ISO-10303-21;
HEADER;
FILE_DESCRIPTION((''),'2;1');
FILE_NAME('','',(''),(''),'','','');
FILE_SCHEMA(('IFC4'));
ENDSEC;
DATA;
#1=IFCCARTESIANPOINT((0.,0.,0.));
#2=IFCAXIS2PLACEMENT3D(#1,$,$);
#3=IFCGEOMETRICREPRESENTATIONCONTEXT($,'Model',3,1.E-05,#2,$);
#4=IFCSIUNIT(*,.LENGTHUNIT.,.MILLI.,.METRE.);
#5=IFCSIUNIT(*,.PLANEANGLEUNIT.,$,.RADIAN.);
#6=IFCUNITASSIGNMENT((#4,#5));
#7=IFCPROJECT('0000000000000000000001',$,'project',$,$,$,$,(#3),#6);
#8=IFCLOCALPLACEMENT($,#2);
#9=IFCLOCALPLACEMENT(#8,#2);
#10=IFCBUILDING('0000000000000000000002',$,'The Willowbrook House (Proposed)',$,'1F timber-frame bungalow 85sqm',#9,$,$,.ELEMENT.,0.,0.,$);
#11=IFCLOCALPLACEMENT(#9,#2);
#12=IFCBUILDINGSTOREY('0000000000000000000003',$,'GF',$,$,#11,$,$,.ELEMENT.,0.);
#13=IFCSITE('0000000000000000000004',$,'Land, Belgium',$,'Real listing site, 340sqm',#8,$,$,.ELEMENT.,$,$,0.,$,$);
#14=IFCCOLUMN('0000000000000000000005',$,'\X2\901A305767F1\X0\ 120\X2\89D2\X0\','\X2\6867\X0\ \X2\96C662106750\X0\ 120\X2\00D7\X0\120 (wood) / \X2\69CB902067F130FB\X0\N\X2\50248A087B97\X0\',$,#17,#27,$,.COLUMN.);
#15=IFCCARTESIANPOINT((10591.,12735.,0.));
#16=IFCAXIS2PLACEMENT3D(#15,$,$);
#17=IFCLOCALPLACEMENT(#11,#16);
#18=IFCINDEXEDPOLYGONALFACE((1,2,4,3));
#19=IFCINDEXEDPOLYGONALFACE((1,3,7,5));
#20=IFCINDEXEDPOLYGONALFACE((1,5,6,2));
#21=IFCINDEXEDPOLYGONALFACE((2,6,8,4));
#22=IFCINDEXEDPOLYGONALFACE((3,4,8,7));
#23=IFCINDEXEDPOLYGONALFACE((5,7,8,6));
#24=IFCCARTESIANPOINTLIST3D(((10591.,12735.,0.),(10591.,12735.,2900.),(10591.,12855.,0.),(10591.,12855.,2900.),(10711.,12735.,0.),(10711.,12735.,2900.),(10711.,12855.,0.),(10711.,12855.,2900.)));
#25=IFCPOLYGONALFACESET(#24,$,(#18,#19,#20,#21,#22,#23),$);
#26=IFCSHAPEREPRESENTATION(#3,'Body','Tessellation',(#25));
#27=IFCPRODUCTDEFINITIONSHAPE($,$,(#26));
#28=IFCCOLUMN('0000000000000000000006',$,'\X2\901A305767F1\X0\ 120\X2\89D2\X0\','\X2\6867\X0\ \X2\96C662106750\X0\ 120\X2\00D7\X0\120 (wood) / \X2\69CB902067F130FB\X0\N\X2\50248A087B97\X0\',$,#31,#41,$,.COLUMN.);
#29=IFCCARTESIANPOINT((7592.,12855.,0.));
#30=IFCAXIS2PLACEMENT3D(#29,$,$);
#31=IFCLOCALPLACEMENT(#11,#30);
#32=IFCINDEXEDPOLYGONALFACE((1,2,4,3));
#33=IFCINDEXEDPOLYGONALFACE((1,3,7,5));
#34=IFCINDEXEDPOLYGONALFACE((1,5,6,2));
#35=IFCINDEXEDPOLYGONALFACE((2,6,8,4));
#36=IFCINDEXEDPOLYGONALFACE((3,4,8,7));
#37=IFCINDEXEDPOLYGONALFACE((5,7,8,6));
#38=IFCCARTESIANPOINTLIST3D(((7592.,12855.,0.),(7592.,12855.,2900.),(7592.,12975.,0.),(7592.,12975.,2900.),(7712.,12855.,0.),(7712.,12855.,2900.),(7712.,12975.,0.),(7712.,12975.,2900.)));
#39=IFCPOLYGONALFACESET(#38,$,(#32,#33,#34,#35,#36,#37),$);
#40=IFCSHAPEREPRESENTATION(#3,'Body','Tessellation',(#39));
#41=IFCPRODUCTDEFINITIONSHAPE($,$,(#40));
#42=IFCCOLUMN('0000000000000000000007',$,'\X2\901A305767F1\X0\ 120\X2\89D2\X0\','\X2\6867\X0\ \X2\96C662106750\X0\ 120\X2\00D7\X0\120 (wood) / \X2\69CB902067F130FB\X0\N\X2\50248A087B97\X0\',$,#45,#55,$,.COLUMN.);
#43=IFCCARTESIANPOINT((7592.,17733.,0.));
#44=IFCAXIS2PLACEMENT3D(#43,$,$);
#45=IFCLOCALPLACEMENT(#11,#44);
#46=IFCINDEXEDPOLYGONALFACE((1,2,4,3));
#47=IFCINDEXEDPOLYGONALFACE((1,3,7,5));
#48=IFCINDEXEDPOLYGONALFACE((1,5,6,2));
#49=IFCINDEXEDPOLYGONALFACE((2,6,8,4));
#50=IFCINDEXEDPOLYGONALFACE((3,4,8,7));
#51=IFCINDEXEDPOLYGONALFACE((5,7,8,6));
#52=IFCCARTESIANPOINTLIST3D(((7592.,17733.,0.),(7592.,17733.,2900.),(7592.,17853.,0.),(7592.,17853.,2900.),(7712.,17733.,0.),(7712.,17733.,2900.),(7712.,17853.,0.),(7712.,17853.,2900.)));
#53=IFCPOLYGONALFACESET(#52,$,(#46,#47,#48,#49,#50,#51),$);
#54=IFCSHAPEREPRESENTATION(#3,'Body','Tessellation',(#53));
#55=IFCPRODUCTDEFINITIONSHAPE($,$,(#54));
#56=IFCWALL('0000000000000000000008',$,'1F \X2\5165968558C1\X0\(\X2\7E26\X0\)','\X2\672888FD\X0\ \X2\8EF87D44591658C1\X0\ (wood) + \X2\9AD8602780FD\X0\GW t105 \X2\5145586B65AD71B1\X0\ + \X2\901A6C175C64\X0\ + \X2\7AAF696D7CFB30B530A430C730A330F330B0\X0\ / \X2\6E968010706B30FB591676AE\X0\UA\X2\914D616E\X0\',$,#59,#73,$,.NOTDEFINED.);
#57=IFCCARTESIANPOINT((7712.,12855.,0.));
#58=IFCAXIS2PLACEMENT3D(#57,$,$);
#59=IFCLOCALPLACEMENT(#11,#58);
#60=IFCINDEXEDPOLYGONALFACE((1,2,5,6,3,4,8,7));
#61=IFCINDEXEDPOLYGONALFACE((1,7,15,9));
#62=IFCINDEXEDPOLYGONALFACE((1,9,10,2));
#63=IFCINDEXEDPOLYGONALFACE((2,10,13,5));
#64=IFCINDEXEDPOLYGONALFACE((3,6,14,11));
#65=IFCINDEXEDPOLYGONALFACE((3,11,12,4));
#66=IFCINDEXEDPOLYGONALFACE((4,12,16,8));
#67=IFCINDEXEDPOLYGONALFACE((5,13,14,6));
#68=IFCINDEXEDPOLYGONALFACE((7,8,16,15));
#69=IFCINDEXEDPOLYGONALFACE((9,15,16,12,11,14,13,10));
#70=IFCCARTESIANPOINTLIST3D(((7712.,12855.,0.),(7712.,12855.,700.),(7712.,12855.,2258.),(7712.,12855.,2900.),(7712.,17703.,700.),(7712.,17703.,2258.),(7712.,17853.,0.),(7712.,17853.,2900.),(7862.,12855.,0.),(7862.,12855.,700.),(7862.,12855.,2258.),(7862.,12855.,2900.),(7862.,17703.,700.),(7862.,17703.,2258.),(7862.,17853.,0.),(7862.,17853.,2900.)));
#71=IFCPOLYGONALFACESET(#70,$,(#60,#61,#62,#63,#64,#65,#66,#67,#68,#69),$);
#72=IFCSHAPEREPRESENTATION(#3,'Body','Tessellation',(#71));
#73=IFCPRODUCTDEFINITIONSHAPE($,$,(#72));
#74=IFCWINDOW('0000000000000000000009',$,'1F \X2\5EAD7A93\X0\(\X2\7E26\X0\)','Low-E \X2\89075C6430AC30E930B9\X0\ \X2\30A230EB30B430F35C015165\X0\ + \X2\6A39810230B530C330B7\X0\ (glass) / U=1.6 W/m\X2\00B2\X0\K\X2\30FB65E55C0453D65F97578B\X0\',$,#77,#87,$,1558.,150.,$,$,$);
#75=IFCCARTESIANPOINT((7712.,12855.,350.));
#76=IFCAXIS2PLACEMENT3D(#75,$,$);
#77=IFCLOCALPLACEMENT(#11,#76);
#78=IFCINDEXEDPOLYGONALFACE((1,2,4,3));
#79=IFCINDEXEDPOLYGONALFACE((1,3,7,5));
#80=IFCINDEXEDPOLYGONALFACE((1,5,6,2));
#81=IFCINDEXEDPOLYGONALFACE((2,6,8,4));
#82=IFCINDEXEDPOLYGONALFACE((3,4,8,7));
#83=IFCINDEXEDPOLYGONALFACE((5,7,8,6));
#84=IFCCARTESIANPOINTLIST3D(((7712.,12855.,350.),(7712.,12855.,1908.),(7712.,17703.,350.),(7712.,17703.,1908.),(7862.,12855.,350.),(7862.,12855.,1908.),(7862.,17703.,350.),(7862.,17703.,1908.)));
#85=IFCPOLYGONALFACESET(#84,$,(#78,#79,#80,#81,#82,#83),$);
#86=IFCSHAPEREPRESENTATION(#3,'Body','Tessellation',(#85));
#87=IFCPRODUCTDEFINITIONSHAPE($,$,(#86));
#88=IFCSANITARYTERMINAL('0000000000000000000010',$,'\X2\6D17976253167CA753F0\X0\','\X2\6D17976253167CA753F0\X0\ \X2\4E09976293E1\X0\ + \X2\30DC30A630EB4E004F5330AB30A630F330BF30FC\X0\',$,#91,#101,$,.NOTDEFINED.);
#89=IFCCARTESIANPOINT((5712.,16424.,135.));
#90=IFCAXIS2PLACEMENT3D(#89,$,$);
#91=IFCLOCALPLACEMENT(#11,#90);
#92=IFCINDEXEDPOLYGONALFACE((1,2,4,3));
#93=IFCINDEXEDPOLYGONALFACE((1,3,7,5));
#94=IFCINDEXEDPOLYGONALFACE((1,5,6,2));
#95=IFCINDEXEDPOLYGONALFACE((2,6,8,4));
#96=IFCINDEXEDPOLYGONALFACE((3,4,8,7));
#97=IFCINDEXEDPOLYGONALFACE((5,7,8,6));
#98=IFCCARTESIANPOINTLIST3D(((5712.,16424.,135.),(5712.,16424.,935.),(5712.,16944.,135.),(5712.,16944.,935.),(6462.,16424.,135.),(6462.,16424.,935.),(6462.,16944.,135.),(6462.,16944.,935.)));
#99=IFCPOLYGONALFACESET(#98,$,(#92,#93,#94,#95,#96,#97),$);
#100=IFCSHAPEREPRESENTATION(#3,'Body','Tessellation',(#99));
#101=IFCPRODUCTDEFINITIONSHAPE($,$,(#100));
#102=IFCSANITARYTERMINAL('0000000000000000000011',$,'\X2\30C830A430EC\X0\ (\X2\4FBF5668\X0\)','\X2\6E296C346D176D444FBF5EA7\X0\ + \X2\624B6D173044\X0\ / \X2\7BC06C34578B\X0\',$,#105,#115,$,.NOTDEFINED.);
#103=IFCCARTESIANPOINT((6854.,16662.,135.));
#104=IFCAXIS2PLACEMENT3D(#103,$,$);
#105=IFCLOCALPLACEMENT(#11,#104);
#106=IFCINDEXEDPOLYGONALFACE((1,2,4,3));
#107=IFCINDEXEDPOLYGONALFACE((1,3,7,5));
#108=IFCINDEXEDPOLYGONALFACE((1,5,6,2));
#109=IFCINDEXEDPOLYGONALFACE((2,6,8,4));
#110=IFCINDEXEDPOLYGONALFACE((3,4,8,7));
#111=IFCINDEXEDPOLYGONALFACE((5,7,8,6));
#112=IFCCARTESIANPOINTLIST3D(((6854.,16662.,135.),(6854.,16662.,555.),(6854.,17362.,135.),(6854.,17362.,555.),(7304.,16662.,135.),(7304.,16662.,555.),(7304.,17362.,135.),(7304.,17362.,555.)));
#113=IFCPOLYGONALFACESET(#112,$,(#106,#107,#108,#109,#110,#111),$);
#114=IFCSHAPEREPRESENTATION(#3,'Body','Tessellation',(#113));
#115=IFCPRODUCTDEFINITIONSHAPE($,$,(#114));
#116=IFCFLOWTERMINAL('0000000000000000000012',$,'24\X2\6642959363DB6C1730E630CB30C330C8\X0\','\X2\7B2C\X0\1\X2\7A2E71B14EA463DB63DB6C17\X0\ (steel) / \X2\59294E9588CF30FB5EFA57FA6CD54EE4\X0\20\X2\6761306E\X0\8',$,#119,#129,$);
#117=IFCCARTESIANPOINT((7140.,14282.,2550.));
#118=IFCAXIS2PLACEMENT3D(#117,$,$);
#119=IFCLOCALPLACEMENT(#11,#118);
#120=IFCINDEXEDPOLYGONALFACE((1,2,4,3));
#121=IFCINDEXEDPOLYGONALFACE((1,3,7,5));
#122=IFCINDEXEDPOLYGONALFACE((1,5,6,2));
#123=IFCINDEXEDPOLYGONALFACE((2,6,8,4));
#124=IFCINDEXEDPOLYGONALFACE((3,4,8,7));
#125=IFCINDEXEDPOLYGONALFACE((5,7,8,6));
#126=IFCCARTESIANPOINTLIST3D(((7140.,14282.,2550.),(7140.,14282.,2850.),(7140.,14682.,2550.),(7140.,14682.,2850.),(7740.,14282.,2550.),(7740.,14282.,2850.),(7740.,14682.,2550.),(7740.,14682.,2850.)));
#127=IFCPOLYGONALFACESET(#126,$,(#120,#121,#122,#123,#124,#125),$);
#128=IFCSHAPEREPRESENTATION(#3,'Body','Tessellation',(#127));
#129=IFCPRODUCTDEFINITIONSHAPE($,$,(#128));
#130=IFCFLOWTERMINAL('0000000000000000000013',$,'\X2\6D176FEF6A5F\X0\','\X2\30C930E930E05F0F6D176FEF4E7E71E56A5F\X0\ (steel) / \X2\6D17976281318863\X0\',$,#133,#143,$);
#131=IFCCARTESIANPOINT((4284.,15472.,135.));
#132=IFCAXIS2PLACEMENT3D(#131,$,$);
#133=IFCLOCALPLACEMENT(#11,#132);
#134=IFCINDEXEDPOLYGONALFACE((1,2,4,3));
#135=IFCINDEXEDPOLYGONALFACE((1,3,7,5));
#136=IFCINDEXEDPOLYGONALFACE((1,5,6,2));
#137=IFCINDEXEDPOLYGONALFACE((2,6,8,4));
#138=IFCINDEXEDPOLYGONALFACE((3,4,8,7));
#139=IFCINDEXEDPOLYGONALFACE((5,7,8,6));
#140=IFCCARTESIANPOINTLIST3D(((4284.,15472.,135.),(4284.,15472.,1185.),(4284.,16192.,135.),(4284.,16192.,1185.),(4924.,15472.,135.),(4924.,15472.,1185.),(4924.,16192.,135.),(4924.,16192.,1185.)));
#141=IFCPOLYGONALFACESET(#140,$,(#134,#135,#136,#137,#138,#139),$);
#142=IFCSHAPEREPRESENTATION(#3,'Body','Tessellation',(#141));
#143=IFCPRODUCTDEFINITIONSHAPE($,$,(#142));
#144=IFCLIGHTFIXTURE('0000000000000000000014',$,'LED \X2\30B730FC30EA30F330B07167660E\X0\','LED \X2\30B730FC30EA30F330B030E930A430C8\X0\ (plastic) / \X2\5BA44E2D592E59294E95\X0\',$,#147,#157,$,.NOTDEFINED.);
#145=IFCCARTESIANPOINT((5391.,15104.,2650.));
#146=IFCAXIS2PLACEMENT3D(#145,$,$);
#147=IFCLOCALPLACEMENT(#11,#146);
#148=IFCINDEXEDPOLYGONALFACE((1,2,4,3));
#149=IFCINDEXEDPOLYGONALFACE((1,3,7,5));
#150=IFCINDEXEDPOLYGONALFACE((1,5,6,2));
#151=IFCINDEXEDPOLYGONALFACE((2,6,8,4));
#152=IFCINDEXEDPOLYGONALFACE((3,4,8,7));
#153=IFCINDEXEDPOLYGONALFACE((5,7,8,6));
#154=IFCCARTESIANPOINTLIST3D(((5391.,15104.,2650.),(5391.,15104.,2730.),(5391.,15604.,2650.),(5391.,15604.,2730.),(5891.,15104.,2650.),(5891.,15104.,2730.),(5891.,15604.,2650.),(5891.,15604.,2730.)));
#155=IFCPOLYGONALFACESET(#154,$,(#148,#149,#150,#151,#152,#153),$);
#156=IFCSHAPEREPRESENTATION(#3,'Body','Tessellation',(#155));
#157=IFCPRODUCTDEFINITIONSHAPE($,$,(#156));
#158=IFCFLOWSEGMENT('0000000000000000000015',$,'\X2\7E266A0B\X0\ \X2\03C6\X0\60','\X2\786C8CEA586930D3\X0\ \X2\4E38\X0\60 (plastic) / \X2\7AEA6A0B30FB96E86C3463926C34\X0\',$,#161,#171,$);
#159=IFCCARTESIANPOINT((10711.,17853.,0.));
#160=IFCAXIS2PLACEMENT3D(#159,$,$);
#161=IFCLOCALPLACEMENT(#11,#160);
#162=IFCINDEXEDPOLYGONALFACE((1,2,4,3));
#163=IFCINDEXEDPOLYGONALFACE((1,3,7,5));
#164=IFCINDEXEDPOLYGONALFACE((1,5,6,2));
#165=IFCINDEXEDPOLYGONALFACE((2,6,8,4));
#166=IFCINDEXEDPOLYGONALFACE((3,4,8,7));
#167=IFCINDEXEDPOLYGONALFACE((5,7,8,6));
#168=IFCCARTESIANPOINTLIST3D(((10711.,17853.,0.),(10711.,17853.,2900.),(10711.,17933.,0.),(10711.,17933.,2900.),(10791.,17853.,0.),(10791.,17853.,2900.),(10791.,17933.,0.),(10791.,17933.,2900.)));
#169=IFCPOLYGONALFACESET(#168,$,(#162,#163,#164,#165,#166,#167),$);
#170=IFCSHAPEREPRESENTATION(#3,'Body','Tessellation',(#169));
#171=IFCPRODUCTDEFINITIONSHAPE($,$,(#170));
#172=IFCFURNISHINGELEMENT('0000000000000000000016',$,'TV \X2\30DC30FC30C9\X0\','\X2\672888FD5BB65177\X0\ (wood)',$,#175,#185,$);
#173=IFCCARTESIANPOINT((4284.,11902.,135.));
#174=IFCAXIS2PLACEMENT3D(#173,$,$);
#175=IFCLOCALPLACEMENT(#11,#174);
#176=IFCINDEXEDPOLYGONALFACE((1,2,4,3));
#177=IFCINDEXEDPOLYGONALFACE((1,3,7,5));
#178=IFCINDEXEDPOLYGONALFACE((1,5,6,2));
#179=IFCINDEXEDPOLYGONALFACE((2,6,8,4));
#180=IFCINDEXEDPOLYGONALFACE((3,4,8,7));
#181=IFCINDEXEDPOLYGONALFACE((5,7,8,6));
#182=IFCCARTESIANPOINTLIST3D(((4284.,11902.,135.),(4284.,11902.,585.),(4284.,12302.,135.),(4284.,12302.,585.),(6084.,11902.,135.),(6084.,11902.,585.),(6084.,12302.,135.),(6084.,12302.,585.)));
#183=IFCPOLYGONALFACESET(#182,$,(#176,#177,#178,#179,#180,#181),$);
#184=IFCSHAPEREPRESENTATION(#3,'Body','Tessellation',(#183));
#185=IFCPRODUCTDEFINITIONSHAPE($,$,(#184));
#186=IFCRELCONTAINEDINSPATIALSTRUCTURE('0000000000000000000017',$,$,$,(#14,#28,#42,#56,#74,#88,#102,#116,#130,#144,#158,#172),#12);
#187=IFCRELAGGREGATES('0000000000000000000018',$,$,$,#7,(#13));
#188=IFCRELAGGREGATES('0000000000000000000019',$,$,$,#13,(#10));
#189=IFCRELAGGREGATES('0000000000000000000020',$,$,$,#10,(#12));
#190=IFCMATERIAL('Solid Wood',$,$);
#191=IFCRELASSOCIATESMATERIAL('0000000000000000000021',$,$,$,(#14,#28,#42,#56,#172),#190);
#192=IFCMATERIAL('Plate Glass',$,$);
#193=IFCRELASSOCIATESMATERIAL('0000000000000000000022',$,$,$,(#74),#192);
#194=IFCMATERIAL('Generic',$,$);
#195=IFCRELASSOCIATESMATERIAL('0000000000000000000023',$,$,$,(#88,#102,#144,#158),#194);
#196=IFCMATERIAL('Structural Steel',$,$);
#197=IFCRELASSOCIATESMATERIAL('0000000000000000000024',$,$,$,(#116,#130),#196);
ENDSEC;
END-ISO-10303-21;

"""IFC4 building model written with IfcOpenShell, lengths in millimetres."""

from ifc_helpers import new_model, si_unit, frame, frame_2d, origin, place, context, project, spatial, rectangle, extrude, material, element, fill, save


model = new_model("IFC4")

# Units and contexts
model_context = context("Model", 3, precision=1e-05, world=origin())
ifc_project = project(units=[si_unit("LENGTHUNIT", "METRE", prefix="MILLI"), si_unit("PLANEANGLEUNIT", "RADIAN")], contexts=[model_context])

# Site, building, storey
site_placement = place(None, origin())
site = spatial("IfcSite", under=ifc_project, at=site_placement, Name="Land, Belgium", ObjectType="Real listing site, 340sqm", CompositionType="ELEMENT", RefElevation=0.0)
building_placement = place(site_placement, origin())
building = spatial("IfcBuilding", under=site, at=building_placement, Name="The Willowbrook House (Proposed)", ObjectType="1F timber-frame bungalow 85sqm", CompositionType="ELEMENT", ElevationOfRefHeight=0.0, ElevationOfTerrain=0.0)
storey_placement = place(building_placement, origin())
storey = spatial("IfcBuildingStorey", under=building, at=storey_placement, Name="GF", CompositionType="ELEMENT", Elevation=0.0)

# Columns
ifc_material_1 = material(Name="Solid Wood")
column_1_placement = place(storey_placement, frame((10591.0, 12735.0, 0.0)))
element("IfcColumn", 1, at=column_1_placement, inside=storey, material=ifc_material_1, Name="通し柱 120角", Description="桧 集成材 120×120 (wood) / 構造柱・N値計算", PredefinedType="COLUMN", context=model_context, shape_type="SweptSolid", body=[
    extrude(rectangle(XDim=120.0, YDim=120.0, at=frame_2d((60.0, 60.0))), frame((10591.0, 12735.0, 0.0)), (0.0, 0.0, 1.0), 2900.0),
])
column_2_placement = place(storey_placement, frame((7592.0, 12855.0, 0.0)))
element("IfcColumn", 2, at=column_2_placement, inside=storey, material=ifc_material_1, Name="通し柱 120角", Description="桧 集成材 120×120 (wood) / 構造柱・N値計算", PredefinedType="COLUMN", context=model_context, shape_type="SweptSolid", body=[
    extrude(rectangle(XDim=120.0, YDim=120.0, at=frame_2d((60.0, 60.0))), frame((7592.0, 12855.0, 0.0)), (0.0, 0.0, 1.0), 2900.0),
])
column_3_placement = place(storey_placement, frame((7592.0, 17733.0, 0.0)))
element("IfcColumn", 3, at=column_3_placement, inside=storey, material=ifc_material_1, Name="通し柱 120角", Description="桧 集成材 120×120 (wood) / 構造柱・N値計算", PredefinedType="COLUMN", context=model_context, shape_type="SweptSolid", body=[
    extrude(rectangle(XDim=120.0, YDim=120.0, at=frame_2d((60.0, 60.0))), frame((7592.0, 17733.0, 0.0)), (0.0, 0.0, 1.0), 2900.0),
])

# Wall, opening, window
wall_1_placement = place(storey_placement, frame((7712.0, 12855.0, 0.0)))
wall_1 = element("IfcWall", 4, at=wall_1_placement, inside=storey, material=ifc_material_1, Name="1F 入隅壁(縦)", Description="木製 軸組外壁 (wood) + 高性能GW t105 充填断熱 + 通気層 + 窯業系サイディング / 準耐火・外皮UA配慮", PredefinedType="NOTDEFINED", context=model_context, shape_type="SweptSolid", body=[
    extrude(rectangle(XDim=150.0, YDim=4998.0, at=frame_2d((75.0, 2499.0))), frame((7712.0, 12855.0, 0.0)), (0.0, 0.0, 1.0), 2900.0),
])
opening_placement = place(storey_placement, frame((7712.0, 12855.0, 350.0)))
opening = element("IfcOpeningElement", 5, at=opening_placement, cuts=wall_1, PredefinedType="NOTDEFINED", context=model_context, shape_type="SweptSolid", body=[
    extrude(rectangle(XDim=150.0, YDim=4848.0, at=frame_2d((75.0, 2424.0))), frame((7712.0, 12855.0, 350.0)), (0.0, 0.0, 1.0), 1558.0),
])
ifc_material_2 = material(Name="Plate Glass")
window_placement = place(storey_placement, frame((7712.0, 12855.0, 350.0)))
window = element("IfcWindow", 6, at=window_placement, inside=storey, material=ifc_material_2, Name="1F 庭窓(縦)", Description="Low-E 複層ガラス アルゴン封入 + 樹脂サッシ (glass) / U=1.6 W/m²K・日射取得型", OverallHeight=1558.0, OverallWidth=150.0, context=model_context, shape_type="SweptSolid", body=[
    extrude(rectangle(XDim=150.0, YDim=4848.0, at=frame_2d((75.0, 2424.0))), frame((7712.0, 12855.0, 350.0)), (0.0, 0.0, 1.0), 1558.0),
])
fill(opening, window)

# Sanitary terminals
ifc_material_3 = material(Name="Generic")
sanitary_terminal_1_placement = place(storey_placement, frame((5712.0, 16424.0, 135.0)))
element("IfcSanitaryTerminal", 7, at=sanitary_terminal_1_placement, inside=storey, material=ifc_material_3, Name="洗面化粧台", Description="洗面化粧台 三面鏡 + ボウル一体カウンター", PredefinedType="NOTDEFINED", context=model_context, shape_type="SweptSolid", body=[
    extrude(rectangle(XDim=750.0, YDim=520.0, at=frame_2d((375.0, 260.0))), frame((5712.0, 16424.0, 135.0)), (0.0, 0.0, 1.0), 800.0),
])
sanitary_terminal_2_placement = place(storey_placement, frame((6854.0, 16662.0, 135.0)))
element("IfcSanitaryTerminal", 8, at=sanitary_terminal_2_placement, inside=storey, material=ifc_material_3, Name="トイレ (便器)", Description="温水洗浄便座 + 手洗い / 節水型", PredefinedType="NOTDEFINED", context=model_context, shape_type="SweptSolid", body=[
    extrude(rectangle(XDim=450.0, YDim=700.0, at=frame_2d((225.0, 350.0))), frame((6854.0, 16662.0, 135.0)), (0.0, 0.0, 1.0), 420.0),
])

# Flow terminals
ifc_material_4 = material(Name="Structural Steel")
flow_terminal_1_placement = place(storey_placement, frame((7140.0, 14282.0, 2550.0)))
element("IfcFlowTerminal", 9, at=flow_terminal_1_placement, inside=storey, material=ifc_material_4, Name="24時間換気ユニット", Description="第1種熱交換換気 (steel) / 天井裏・建基法令20条の8", context=model_context, shape_type="SweptSolid", body=[
    extrude(rectangle(XDim=600.0, YDim=400.0, at=frame_2d((300.0, 200.0))), frame((7140.0, 14282.0, 2550.0)), (0.0, 0.0, 1.0), 300.0),
])
flow_terminal_2_placement = place(storey_placement, frame((4284.0, 15472.0, 135.0)))
element("IfcFlowTerminal", 10, at=flow_terminal_2_placement, inside=storey, material=ifc_material_4, Name="洗濯機", Description="ドラム式洗濯乾燥機 (steel) / 洗面脱衣", context=model_context, shape_type="SweptSolid", body=[
    extrude(rectangle(XDim=640.0, YDim=720.0, at=frame_2d((320.0, 360.0))), frame((4284.0, 15472.0, 135.0)), (0.0, 0.0, 1.0), 1050.0),
])

# Light fixture
light_fixture_placement = place(storey_placement, frame((5391.0, 15104.0, 2650.0)))
element("IfcLightFixture", 11, at=light_fixture_placement, inside=storey, material=ifc_material_3, Name="LED シーリング照明", Description="LED シーリングライト (plastic) / 室中央天井", PredefinedType="NOTDEFINED", context=model_context, shape_type="SweptSolid", body=[
    extrude(rectangle(XDim=500.0, YDim=500.0, at=frame_2d((250.0, 250.0))), frame((5391.0, 15104.0, 2650.0)), (0.0, 0.0, 1.0), 80.0),
])

# Flow segment
flow_segment_placement = place(storey_placement, frame((10711.0, 17853.0, 0.0)))
element("IfcFlowSegment", 12, at=flow_segment_placement, inside=storey, material=ifc_material_3, Name="縦樋 φ60", Description="硬質塩ビ 丸60 (plastic) / 竪樋・雨水排水", context=model_context, shape_type="SweptSolid", body=[
    extrude(rectangle(XDim=80.0, YDim=80.0, at=frame_2d((40.0, 40.0))), frame((10711.0, 17853.0, 0.0)), (0.0, 0.0, 1.0), 2900.0),
])

# Furnishing element
furnishing_placement = place(storey_placement, frame((4284.0, 11902.0, 135.0)))
element("IfcFurnishingElement", 13, at=furnishing_placement, inside=storey, material=ifc_material_1, Name="TV ボード", Description="木製家具 (wood)", context=model_context, shape_type="SweptSolid", body=[
    extrude(rectangle(XDim=1800.0, YDim=400.0, at=frame_2d((900.0, 200.0))), frame((4284.0, 11902.0, 135.0)), (0.0, 0.0, 1.0), 450.0),
])

save(model, "model.ifc")
